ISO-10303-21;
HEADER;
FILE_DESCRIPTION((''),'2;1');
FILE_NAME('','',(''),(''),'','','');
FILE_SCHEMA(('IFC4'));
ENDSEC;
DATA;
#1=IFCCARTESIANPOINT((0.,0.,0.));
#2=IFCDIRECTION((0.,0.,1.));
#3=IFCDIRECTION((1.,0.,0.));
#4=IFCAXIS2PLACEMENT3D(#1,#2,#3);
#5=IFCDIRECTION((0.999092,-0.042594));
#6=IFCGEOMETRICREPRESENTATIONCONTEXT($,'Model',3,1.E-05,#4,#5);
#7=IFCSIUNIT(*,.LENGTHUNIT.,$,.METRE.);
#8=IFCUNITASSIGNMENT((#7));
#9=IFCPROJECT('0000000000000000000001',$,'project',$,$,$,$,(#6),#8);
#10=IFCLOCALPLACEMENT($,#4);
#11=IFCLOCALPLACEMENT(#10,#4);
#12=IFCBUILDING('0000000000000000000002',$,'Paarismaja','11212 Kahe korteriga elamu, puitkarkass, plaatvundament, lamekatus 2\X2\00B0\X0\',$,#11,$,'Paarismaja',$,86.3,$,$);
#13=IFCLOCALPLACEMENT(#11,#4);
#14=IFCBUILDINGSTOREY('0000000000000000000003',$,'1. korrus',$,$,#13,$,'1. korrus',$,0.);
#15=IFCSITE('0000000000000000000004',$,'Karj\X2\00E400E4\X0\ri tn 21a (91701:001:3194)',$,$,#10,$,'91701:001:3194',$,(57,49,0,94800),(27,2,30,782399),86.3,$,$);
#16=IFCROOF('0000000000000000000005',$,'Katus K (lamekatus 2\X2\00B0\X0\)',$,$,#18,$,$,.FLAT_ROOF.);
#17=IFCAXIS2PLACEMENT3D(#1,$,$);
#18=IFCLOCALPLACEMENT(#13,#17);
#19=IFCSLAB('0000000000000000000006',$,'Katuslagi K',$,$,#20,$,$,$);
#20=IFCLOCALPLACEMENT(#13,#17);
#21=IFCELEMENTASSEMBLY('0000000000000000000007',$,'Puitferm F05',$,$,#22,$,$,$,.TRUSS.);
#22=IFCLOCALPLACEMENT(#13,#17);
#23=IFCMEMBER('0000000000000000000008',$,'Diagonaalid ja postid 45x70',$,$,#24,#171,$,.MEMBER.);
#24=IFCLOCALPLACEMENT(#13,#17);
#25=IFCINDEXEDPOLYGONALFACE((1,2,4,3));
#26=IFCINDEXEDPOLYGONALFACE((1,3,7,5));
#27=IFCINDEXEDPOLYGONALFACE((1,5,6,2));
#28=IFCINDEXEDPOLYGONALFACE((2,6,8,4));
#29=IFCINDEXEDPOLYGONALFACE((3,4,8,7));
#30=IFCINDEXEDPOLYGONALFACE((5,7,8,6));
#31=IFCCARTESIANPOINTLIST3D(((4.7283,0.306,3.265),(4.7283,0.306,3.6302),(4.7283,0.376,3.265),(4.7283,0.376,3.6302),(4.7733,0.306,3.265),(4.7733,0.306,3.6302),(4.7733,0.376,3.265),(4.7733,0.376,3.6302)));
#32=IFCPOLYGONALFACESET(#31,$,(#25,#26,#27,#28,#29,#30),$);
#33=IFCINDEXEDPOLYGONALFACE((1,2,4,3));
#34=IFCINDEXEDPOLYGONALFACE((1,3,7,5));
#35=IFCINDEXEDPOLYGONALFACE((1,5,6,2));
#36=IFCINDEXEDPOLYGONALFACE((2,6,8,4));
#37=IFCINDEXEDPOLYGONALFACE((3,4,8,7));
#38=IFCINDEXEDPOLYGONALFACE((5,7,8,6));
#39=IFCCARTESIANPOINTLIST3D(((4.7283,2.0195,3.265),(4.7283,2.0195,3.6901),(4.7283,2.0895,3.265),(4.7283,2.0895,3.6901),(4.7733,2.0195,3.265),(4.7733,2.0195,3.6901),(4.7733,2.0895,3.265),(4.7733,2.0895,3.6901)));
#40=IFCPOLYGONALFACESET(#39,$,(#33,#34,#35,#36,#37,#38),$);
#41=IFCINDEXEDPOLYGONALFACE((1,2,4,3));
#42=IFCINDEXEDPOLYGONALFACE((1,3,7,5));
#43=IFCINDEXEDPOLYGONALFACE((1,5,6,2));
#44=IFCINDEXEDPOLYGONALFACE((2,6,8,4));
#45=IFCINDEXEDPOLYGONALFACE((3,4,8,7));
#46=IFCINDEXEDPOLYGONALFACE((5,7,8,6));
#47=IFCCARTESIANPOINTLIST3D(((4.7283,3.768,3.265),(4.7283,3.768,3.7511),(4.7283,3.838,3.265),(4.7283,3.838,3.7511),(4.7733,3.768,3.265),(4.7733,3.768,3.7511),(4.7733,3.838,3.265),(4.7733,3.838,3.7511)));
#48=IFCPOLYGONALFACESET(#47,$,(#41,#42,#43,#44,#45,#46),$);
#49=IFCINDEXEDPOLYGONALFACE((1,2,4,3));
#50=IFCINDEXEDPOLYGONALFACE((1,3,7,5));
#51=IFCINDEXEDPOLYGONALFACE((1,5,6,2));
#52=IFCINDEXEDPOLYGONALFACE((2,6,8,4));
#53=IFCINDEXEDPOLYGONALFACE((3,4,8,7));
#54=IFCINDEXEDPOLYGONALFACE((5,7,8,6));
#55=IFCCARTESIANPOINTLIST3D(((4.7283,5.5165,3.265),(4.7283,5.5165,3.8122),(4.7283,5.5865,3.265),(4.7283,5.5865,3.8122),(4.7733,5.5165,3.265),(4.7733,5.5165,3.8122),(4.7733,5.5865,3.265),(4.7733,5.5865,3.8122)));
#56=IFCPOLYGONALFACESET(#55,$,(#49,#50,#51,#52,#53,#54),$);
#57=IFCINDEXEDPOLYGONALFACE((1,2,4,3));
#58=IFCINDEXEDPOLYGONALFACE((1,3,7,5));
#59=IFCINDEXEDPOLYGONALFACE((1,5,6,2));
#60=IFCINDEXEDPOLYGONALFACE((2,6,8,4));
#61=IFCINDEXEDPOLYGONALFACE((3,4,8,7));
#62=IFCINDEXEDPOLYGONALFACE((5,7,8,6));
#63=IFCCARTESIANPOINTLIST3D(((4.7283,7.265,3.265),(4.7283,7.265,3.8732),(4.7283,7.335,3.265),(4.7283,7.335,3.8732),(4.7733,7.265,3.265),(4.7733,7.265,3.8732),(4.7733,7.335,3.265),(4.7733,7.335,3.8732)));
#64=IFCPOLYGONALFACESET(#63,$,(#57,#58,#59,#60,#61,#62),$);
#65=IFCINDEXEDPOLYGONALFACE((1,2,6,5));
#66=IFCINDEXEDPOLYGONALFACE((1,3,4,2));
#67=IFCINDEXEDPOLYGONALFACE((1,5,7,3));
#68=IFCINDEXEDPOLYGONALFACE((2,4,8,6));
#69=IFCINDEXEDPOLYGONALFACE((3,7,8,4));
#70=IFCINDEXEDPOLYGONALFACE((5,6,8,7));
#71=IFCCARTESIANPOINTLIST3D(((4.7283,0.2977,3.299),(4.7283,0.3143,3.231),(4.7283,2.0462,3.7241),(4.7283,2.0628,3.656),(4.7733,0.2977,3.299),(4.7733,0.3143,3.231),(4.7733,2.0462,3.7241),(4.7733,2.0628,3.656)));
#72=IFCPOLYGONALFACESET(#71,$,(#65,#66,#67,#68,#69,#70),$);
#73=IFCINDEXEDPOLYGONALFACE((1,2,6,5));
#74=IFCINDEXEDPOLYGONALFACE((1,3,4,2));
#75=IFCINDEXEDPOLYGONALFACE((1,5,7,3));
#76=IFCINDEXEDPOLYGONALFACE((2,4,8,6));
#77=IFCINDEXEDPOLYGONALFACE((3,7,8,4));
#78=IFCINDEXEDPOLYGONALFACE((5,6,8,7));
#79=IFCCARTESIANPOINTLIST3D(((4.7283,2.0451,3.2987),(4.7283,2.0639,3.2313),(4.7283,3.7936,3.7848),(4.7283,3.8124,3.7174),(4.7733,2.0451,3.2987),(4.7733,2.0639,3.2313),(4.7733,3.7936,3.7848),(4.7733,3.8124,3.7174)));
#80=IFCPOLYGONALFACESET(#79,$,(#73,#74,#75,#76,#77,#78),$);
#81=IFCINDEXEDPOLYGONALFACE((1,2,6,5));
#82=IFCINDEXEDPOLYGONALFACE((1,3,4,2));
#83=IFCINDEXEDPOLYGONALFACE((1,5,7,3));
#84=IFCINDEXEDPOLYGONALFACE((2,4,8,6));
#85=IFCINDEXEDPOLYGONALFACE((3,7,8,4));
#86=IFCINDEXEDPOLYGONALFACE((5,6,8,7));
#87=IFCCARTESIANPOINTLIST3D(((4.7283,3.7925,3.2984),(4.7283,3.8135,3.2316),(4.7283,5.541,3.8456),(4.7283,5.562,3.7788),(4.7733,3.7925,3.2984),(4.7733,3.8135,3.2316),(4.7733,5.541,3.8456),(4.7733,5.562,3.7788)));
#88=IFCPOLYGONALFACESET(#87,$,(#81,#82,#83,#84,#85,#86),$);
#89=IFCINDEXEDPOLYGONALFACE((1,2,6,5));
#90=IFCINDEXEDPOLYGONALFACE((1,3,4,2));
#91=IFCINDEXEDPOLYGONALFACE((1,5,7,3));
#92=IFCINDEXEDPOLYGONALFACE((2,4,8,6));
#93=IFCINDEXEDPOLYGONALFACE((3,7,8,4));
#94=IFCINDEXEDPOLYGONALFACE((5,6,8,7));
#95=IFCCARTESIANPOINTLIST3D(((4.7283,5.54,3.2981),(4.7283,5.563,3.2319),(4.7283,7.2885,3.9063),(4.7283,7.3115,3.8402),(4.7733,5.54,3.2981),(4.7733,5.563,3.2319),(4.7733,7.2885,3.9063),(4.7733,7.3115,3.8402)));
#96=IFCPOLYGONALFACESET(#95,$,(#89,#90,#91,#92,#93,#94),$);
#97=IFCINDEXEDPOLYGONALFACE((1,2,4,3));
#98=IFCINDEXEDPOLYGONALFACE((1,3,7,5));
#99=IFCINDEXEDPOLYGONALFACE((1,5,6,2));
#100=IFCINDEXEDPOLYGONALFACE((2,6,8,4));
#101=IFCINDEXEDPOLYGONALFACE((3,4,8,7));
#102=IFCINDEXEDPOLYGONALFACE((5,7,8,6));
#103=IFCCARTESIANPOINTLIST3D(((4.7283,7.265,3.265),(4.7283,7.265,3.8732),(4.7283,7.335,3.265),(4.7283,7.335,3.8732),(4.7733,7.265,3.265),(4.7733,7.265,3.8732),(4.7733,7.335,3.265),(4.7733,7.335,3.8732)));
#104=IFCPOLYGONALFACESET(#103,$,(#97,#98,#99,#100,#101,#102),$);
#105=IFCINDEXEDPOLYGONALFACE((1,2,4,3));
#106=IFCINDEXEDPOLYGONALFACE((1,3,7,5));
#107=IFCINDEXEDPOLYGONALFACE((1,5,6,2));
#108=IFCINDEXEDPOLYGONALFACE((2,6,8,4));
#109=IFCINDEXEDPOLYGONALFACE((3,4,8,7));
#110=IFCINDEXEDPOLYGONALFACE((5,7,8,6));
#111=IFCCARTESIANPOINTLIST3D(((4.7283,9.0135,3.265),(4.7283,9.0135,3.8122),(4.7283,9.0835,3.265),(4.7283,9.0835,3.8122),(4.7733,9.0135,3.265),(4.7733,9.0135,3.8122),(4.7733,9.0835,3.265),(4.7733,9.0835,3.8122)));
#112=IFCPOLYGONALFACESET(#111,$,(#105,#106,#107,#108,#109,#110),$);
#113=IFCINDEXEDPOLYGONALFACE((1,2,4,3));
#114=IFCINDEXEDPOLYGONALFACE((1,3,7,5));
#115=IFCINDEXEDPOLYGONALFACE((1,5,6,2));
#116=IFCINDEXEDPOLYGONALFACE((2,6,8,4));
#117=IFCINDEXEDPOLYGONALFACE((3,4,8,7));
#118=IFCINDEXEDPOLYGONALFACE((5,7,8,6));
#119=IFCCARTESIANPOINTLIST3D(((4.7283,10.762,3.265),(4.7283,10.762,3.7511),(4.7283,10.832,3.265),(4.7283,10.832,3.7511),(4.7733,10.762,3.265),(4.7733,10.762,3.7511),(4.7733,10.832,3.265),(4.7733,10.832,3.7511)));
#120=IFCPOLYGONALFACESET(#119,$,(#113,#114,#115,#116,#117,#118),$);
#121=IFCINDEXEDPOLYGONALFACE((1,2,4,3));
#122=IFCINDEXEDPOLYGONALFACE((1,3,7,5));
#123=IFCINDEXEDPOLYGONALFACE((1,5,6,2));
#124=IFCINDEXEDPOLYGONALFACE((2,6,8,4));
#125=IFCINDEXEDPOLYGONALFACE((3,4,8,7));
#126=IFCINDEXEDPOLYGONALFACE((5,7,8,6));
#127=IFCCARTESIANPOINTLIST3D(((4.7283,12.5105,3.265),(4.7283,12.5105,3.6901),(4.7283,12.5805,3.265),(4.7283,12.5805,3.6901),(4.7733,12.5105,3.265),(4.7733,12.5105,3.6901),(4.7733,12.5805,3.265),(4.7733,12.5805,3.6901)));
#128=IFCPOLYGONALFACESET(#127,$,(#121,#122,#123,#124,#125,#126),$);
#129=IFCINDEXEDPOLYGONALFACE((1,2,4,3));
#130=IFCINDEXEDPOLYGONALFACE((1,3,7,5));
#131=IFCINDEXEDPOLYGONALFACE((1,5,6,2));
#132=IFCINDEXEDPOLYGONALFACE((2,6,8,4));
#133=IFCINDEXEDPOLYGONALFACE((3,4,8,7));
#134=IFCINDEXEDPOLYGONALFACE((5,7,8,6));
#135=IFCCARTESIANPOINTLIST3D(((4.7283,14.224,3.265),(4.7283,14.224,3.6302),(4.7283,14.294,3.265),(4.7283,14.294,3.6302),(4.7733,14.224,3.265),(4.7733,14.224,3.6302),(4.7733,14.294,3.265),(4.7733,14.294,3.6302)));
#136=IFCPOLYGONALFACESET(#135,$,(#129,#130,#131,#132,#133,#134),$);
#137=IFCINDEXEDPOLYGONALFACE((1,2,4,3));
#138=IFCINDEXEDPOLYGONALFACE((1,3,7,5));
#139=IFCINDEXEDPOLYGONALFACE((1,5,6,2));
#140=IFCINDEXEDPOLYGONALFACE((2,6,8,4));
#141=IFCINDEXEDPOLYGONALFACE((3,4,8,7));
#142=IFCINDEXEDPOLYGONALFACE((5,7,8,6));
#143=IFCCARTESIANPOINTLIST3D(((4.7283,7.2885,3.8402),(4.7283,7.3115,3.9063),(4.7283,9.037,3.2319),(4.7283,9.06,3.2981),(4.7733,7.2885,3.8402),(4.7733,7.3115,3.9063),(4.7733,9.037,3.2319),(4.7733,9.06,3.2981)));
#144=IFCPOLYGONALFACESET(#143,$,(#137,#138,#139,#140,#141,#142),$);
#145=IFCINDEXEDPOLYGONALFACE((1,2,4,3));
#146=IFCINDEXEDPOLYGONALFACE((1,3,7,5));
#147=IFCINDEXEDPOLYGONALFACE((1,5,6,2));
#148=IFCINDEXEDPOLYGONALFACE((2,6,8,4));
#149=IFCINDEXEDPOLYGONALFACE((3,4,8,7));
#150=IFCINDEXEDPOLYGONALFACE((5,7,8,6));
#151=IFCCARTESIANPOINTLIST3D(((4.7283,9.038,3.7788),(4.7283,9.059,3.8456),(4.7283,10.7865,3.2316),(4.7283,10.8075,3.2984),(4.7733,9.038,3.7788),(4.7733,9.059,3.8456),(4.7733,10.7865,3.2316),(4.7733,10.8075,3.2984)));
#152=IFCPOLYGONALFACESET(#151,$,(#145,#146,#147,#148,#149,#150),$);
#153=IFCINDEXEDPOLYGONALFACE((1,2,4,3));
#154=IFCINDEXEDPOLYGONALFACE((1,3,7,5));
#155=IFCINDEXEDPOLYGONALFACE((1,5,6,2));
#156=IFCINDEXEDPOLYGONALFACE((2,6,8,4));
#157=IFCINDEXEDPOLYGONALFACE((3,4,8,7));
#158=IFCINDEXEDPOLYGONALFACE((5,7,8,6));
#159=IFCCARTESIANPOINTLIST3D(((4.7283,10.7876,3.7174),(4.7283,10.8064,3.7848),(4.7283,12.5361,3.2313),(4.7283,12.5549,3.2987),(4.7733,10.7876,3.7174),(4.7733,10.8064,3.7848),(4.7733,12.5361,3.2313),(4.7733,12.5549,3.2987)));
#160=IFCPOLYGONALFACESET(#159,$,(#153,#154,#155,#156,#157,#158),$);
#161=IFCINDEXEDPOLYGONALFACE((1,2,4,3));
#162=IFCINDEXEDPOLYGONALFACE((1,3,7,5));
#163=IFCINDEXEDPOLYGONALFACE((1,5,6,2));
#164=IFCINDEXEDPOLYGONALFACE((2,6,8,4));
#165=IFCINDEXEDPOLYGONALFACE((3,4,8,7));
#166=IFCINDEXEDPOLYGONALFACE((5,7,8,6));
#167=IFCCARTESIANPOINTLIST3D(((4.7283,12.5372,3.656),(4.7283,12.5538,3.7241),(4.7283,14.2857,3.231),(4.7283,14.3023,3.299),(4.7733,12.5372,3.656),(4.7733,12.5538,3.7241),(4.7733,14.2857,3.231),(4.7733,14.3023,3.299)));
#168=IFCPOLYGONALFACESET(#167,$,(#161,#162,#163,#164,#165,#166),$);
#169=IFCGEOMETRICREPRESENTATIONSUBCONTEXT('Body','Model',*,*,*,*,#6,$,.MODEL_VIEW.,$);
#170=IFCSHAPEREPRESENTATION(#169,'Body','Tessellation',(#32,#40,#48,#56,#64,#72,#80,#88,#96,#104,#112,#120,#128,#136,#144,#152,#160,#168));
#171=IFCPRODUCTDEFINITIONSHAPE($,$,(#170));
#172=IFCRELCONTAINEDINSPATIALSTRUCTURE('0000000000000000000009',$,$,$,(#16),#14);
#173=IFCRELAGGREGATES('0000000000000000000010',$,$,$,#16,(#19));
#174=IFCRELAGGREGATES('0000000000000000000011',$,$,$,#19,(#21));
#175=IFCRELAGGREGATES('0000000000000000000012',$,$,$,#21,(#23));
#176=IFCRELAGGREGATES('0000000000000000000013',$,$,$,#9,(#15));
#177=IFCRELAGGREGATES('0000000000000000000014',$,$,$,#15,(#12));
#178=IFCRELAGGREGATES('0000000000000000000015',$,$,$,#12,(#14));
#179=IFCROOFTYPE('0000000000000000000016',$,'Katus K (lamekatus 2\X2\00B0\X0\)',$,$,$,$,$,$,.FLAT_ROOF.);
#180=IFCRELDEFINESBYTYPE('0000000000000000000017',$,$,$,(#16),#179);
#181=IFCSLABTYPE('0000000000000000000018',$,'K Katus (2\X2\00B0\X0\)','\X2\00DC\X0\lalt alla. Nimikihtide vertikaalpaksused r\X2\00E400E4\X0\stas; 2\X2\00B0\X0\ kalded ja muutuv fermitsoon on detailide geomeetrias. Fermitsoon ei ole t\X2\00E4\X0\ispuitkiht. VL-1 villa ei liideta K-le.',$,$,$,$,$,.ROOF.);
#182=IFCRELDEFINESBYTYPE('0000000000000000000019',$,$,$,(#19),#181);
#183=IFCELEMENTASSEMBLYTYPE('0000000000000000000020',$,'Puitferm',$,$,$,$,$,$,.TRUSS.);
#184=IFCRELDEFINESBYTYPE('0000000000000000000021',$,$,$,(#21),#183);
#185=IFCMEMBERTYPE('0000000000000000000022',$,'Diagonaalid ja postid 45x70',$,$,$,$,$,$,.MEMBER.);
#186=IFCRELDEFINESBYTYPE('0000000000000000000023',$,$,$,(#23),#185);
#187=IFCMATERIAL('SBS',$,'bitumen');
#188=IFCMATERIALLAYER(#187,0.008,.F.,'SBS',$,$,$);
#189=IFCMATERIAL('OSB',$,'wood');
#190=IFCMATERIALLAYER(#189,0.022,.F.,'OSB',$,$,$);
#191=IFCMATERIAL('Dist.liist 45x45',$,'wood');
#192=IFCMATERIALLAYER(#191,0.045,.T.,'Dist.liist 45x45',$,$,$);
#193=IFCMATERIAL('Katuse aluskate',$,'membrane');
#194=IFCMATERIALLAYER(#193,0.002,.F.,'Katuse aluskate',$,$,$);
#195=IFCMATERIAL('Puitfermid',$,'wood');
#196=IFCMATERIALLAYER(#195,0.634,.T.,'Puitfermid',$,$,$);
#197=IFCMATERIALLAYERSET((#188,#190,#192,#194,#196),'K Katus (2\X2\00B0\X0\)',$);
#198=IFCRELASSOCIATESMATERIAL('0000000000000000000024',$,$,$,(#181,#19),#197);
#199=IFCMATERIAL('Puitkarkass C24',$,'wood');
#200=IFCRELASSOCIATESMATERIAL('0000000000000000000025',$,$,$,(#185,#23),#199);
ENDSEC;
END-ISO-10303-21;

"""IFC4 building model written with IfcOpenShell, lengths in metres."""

from ifc_helpers import new_model, si_unit, direction, frame, origin_with_axes, place, context, subcontext, project, spatial, indexed_curve, outline, extrude, material, layer, layer_set, layer_usage, type_object, element, aggregate, save


model = new_model("IFC4")

# Units and contexts
model_context = context("Model", 3, precision=1e-05, world=origin_with_axes(), true_north=direction((0.999092, -0.042594)))
body_context = subcontext(model_context, "Body", "Model", "MODEL_VIEW")
ifc_project = project(units=[si_unit("LENGTHUNIT", "METRE")], contexts=[model_context])

# Site, building, storey
site_placement = place(None, origin_with_axes())
site = spatial("IfcSite", under=ifc_project, at=site_placement, Name="Karjääri tn 21a (91701:001:3194)", LongName="91701:001:3194", RefLatitude=(57, 49, 0, 94800), RefLongitude=(27, 2, 30, 782399), RefElevation=86.3)
building_placement = place(site_placement, origin_with_axes())
building = spatial("IfcBuilding", under=site, at=building_placement, Name="Paarismaja", Description="11212 Kahe korteriga elamu, puitkarkass, plaatvundament, lamekatus 2°", LongName="Paarismaja", ElevationOfRefHeight=86.3)
storey_placement = place(building_placement, origin_with_axes())
storey = spatial("IfcBuildingStorey", under=building, at=storey_placement, Name="1. korrus", LongName="1. korrus", Elevation=0.0)

# Shared definitions
ifc_material_1 = material(Name="Puitkarkass C24", Category="wood")

# Roof, slab, element assembly, member
roof_type = type_object("IfcRoofType", Name="Katus K (lamekatus 2°)", PredefinedType="FLAT_ROOF")
roof_placement = place(storey_placement, origin_with_axes())
roof = element("IfcRoof", 1, at=roof_placement, inside=storey, type_object=roof_type, Name="Katus K (lamekatus 2°)", PredefinedType="FLAT_ROOF")
ifc_material_2 = material(Name="SBS", Category="bitumen")
ifc_layer_1 = layer(ifc_material_2, 0.008, ventilated=False, Name="SBS")
ifc_material_3 = material(Name="OSB", Category="wood")
ifc_layer_2 = layer(ifc_material_3, 0.022, ventilated=False, Name="OSB")
ifc_material_4 = material(Name="Dist.liist 45x45", Category="wood")
ifc_layer_3 = layer(ifc_material_4, 0.045, ventilated=True, Name="Dist.liist 45x45")
ifc_material_5 = material(Name="Katuse aluskate", Category="membrane")
ifc_layer_4 = layer(ifc_material_5, 0.002, ventilated=False, Name="Katuse aluskate")
ifc_material_6 = material(Name="Puitfermid", Category="wood")
ifc_layer_5 = layer(ifc_material_6, 0.634, ventilated=True, Name="Puitfermid")
ifc_layer_set_1 = layer_set([ifc_layer_1, ifc_layer_2, ifc_layer_3, ifc_layer_4, ifc_layer_5], Name="K Katus (2°)")
ifc_layer_usage_1 = layer_usage(ifc_layer_set_1, "AXIS3", "NEGATIVE", 3.801)
slab_type = type_object("IfcSlabType", Name="K Katus (2°)", Description="Ülalt alla. Nimikihtide vertikaalpaksused räästas; 2° kalded ja muutuv fermitsoon on detailide geomeetrias. Fermitsoon ei ole täispuitkiht. VL-1 villa ei liideta K-le.", PredefinedType="ROOF", material=ifc_layer_set_1)
slab_placement = place(roof_placement, origin_with_axes())
slab = element("IfcSlab", 2, at=slab_placement, type_object=slab_type, material=ifc_layer_usage_1, Name="Katuslagi K")
aggregate(roof, [slab])
element_assembly_type = type_object("IfcElementAssemblyType", Name="Puitferm", PredefinedType="TRUSS")
assembly_1_placement = place(slab_placement, frame((4.7283, 0.0, 0.0), z_axis=(0.0, 0.0, 1.0), x_axis=(1.0, 0.0, 0.0)))
assembly_1 = element("IfcElementAssembly", 3, at=assembly_1_placement, type_object=element_assembly_type, Name="Puitferm F05", PredefinedType="TRUSS")
aggregate(slab, [assembly_1])
member_type_1 = type_object("IfcMemberType", Name="Diagonaalid ja postid 45x70", PredefinedType="MEMBER", material=ifc_material_1)
member_1_placement = place(assembly_1_placement, origin_with_axes())
member_1 = element("IfcMember", 4, at=member_1_placement, type_object=member_type_1, material=ifc_material_1, Name="Diagonaalid ja postid 45x70", PredefinedType="MEMBER", context=body_context, shape_type="SweptSolid", body=[
    extrude(outline(indexed_curve([(0.306, 3.265), (0.306, 3.6302), (0.376, 3.6302), (0.376, 3.265), (0.306, 3.265)], self_intersect=False)), frame((0.0, 0.0, 0.0), z_axis=(1.0, 0.0, 0.0), x_axis=(0.0, 1.0, 0.0)), (0.0, 0.0, 1.0), 0.045),
    extrude(outline(indexed_curve([(2.0195, 3.265), (2.0195, 3.6901), (2.0895, 3.6901), (2.0895, 3.265), (2.0195, 3.265)], self_intersect=False)), frame((0.0, 0.0, 0.0), z_axis=(1.0, 0.0, 0.0), x_axis=(0.0, 1.0, 0.0)), (0.0, 0.0, 1.0), 0.045),
    extrude(outline(indexed_curve([(3.768, 3.265), (3.768, 3.7511), (3.838, 3.7511), (3.838, 3.265), (3.768, 3.265)], self_intersect=False)), frame((0.0, 0.0, 0.0), z_axis=(1.0, 0.0, 0.0), x_axis=(0.0, 1.0, 0.0)), (0.0, 0.0, 1.0), 0.045),
    extrude(outline(indexed_curve([(5.5165, 3.265), (5.5165, 3.8122), (5.5865, 3.8122), (5.5865, 3.265), (5.5165, 3.265)], self_intersect=False)), frame((0.0, 0.0, 0.0), z_axis=(1.0, 0.0, 0.0), x_axis=(0.0, 1.0, 0.0)), (0.0, 0.0, 1.0), 0.045),
    extrude(outline(indexed_curve([(7.265, 3.265), (7.265, 3.8732), (7.335, 3.8732), (7.335, 3.265), (7.265, 3.265)], self_intersect=False)), frame((0.0, 0.0, 0.0), z_axis=(1.0, 0.0, 0.0), x_axis=(0.0, 1.0, 0.0)), (0.0, 0.0, 1.0), 0.045),
    extrude(outline(indexed_curve([(0.2977, 3.299), (2.0462, 3.7241), (2.0628, 3.656), (0.3143, 3.231), (0.2977, 3.299)], self_intersect=False)), frame((0.0, 0.0, 0.0), z_axis=(1.0, 0.0, 0.0), x_axis=(0.0, 1.0, 0.0)), (0.0, 0.0, 1.0), 0.045),
    extrude(outline(indexed_curve([(2.0451, 3.2987), (3.7936, 3.7848), (3.8124, 3.7174), (2.0639, 3.2313), (2.0451, 3.2987)], self_intersect=False)), frame((0.0, 0.0, 0.0), z_axis=(1.0, 0.0, 0.0), x_axis=(0.0, 1.0, 0.0)), (0.0, 0.0, 1.0), 0.045),
    extrude(outline(indexed_curve([(3.7925, 3.2984), (5.541, 3.8456), (5.562, 3.7788), (3.8135, 3.2316), (3.7925, 3.2984)], self_intersect=False)), frame((0.0, 0.0, 0.0), z_axis=(1.0, 0.0, 0.0), x_axis=(0.0, 1.0, 0.0)), (0.0, 0.0, 1.0), 0.045),
    extrude(outline(indexed_curve([(5.54, 3.2981), (7.2885, 3.9063), (7.3115, 3.8402), (5.563, 3.2319), (5.54, 3.2981)], self_intersect=False)), frame((0.0, 0.0, 0.0), z_axis=(1.0, 0.0, 0.0), x_axis=(0.0, 1.0, 0.0)), (0.0, 0.0, 1.0), 0.045),
    extrude(outline(indexed_curve([(7.265, 3.265), (7.265, 3.8732), (7.335, 3.8732), (7.335, 3.265), (7.265, 3.265)], self_intersect=False)), frame((0.0, 0.0, 0.0), z_axis=(1.0, 0.0, 0.0), x_axis=(0.0, 1.0, 0.0)), (0.0, 0.0, 1.0), 0.045),
    extrude(outline(indexed_curve([(9.0135, 3.265), (9.0135, 3.8122), (9.0835, 3.8122), (9.0835, 3.265), (9.0135, 3.265)], self_intersect=False)), frame((0.0, 0.0, 0.0), z_axis=(1.0, 0.0, 0.0), x_axis=(0.0, 1.0, 0.0)), (0.0, 0.0, 1.0), 0.045),
    extrude(outline(indexed_curve([(10.762, 3.265), (10.762, 3.7511), (10.832, 3.7511), (10.832, 3.265), (10.762, 3.265)], self_intersect=False)), frame((0.0, 0.0, 0.0), z_axis=(1.0, 0.0, 0.0), x_axis=(0.0, 1.0, 0.0)), (0.0, 0.0, 1.0), 0.045),
    extrude(outline(indexed_curve([(12.5105, 3.265), (12.5105, 3.6901), (12.5805, 3.6901), (12.5805, 3.265), (12.5105, 3.265)], self_intersect=False)), frame((0.0, 0.0, 0.0), z_axis=(1.0, 0.0, 0.0), x_axis=(0.0, 1.0, 0.0)), (0.0, 0.0, 1.0), 0.045),
    extrude(outline(indexed_curve([(14.224, 3.265), (14.224, 3.6302), (14.294, 3.6302), (14.294, 3.265), (14.224, 3.265)], self_intersect=False)), frame((0.0, 0.0, 0.0), z_axis=(1.0, 0.0, 0.0), x_axis=(0.0, 1.0, 0.0)), (0.0, 0.0, 1.0), 0.045),
    extrude(outline(indexed_curve([(9.037, 3.2319), (7.2885, 3.8402), (7.3115, 3.9063), (9.06, 3.2981), (9.037, 3.2319)], self_intersect=False)), frame((0.0, 0.0, 0.0), z_axis=(1.0, 0.0, 0.0), x_axis=(0.0, 1.0, 0.0)), (0.0, 0.0, 1.0), 0.045),
    extrude(outline(indexed_curve([(10.7865, 3.2316), (9.038, 3.7788), (9.059, 3.8456), (10.8075, 3.2984), (10.7865, 3.2316)], self_intersect=False)), frame((0.0, 0.0, 0.0), z_axis=(1.0, 0.0, 0.0), x_axis=(0.0, 1.0, 0.0)), (0.0, 0.0, 1.0), 0.045),
    extrude(outline(indexed_curve([(12.5361, 3.2313), (10.7876, 3.7174), (10.8064, 3.7848), (12.5549, 3.2987), (12.5361, 3.2313)], self_intersect=False)), frame((0.0, 0.0, 0.0), z_axis=(1.0, 0.0, 0.0), x_axis=(0.0, 1.0, 0.0)), (0.0, 0.0, 1.0), 0.045),
    extrude(outline(indexed_curve([(14.2857, 3.231), (12.5372, 3.656), (12.5538, 3.7241), (14.3023, 3.299), (14.2857, 3.231)], self_intersect=False)), frame((0.0, 0.0, 0.0), z_axis=(1.0, 0.0, 0.0), x_axis=(0.0, 1.0, 0.0)), (0.0, 0.0, 1.0), 0.045),
])
aggregate(assembly_1, [member_1])

save(model, "model.ifc")
